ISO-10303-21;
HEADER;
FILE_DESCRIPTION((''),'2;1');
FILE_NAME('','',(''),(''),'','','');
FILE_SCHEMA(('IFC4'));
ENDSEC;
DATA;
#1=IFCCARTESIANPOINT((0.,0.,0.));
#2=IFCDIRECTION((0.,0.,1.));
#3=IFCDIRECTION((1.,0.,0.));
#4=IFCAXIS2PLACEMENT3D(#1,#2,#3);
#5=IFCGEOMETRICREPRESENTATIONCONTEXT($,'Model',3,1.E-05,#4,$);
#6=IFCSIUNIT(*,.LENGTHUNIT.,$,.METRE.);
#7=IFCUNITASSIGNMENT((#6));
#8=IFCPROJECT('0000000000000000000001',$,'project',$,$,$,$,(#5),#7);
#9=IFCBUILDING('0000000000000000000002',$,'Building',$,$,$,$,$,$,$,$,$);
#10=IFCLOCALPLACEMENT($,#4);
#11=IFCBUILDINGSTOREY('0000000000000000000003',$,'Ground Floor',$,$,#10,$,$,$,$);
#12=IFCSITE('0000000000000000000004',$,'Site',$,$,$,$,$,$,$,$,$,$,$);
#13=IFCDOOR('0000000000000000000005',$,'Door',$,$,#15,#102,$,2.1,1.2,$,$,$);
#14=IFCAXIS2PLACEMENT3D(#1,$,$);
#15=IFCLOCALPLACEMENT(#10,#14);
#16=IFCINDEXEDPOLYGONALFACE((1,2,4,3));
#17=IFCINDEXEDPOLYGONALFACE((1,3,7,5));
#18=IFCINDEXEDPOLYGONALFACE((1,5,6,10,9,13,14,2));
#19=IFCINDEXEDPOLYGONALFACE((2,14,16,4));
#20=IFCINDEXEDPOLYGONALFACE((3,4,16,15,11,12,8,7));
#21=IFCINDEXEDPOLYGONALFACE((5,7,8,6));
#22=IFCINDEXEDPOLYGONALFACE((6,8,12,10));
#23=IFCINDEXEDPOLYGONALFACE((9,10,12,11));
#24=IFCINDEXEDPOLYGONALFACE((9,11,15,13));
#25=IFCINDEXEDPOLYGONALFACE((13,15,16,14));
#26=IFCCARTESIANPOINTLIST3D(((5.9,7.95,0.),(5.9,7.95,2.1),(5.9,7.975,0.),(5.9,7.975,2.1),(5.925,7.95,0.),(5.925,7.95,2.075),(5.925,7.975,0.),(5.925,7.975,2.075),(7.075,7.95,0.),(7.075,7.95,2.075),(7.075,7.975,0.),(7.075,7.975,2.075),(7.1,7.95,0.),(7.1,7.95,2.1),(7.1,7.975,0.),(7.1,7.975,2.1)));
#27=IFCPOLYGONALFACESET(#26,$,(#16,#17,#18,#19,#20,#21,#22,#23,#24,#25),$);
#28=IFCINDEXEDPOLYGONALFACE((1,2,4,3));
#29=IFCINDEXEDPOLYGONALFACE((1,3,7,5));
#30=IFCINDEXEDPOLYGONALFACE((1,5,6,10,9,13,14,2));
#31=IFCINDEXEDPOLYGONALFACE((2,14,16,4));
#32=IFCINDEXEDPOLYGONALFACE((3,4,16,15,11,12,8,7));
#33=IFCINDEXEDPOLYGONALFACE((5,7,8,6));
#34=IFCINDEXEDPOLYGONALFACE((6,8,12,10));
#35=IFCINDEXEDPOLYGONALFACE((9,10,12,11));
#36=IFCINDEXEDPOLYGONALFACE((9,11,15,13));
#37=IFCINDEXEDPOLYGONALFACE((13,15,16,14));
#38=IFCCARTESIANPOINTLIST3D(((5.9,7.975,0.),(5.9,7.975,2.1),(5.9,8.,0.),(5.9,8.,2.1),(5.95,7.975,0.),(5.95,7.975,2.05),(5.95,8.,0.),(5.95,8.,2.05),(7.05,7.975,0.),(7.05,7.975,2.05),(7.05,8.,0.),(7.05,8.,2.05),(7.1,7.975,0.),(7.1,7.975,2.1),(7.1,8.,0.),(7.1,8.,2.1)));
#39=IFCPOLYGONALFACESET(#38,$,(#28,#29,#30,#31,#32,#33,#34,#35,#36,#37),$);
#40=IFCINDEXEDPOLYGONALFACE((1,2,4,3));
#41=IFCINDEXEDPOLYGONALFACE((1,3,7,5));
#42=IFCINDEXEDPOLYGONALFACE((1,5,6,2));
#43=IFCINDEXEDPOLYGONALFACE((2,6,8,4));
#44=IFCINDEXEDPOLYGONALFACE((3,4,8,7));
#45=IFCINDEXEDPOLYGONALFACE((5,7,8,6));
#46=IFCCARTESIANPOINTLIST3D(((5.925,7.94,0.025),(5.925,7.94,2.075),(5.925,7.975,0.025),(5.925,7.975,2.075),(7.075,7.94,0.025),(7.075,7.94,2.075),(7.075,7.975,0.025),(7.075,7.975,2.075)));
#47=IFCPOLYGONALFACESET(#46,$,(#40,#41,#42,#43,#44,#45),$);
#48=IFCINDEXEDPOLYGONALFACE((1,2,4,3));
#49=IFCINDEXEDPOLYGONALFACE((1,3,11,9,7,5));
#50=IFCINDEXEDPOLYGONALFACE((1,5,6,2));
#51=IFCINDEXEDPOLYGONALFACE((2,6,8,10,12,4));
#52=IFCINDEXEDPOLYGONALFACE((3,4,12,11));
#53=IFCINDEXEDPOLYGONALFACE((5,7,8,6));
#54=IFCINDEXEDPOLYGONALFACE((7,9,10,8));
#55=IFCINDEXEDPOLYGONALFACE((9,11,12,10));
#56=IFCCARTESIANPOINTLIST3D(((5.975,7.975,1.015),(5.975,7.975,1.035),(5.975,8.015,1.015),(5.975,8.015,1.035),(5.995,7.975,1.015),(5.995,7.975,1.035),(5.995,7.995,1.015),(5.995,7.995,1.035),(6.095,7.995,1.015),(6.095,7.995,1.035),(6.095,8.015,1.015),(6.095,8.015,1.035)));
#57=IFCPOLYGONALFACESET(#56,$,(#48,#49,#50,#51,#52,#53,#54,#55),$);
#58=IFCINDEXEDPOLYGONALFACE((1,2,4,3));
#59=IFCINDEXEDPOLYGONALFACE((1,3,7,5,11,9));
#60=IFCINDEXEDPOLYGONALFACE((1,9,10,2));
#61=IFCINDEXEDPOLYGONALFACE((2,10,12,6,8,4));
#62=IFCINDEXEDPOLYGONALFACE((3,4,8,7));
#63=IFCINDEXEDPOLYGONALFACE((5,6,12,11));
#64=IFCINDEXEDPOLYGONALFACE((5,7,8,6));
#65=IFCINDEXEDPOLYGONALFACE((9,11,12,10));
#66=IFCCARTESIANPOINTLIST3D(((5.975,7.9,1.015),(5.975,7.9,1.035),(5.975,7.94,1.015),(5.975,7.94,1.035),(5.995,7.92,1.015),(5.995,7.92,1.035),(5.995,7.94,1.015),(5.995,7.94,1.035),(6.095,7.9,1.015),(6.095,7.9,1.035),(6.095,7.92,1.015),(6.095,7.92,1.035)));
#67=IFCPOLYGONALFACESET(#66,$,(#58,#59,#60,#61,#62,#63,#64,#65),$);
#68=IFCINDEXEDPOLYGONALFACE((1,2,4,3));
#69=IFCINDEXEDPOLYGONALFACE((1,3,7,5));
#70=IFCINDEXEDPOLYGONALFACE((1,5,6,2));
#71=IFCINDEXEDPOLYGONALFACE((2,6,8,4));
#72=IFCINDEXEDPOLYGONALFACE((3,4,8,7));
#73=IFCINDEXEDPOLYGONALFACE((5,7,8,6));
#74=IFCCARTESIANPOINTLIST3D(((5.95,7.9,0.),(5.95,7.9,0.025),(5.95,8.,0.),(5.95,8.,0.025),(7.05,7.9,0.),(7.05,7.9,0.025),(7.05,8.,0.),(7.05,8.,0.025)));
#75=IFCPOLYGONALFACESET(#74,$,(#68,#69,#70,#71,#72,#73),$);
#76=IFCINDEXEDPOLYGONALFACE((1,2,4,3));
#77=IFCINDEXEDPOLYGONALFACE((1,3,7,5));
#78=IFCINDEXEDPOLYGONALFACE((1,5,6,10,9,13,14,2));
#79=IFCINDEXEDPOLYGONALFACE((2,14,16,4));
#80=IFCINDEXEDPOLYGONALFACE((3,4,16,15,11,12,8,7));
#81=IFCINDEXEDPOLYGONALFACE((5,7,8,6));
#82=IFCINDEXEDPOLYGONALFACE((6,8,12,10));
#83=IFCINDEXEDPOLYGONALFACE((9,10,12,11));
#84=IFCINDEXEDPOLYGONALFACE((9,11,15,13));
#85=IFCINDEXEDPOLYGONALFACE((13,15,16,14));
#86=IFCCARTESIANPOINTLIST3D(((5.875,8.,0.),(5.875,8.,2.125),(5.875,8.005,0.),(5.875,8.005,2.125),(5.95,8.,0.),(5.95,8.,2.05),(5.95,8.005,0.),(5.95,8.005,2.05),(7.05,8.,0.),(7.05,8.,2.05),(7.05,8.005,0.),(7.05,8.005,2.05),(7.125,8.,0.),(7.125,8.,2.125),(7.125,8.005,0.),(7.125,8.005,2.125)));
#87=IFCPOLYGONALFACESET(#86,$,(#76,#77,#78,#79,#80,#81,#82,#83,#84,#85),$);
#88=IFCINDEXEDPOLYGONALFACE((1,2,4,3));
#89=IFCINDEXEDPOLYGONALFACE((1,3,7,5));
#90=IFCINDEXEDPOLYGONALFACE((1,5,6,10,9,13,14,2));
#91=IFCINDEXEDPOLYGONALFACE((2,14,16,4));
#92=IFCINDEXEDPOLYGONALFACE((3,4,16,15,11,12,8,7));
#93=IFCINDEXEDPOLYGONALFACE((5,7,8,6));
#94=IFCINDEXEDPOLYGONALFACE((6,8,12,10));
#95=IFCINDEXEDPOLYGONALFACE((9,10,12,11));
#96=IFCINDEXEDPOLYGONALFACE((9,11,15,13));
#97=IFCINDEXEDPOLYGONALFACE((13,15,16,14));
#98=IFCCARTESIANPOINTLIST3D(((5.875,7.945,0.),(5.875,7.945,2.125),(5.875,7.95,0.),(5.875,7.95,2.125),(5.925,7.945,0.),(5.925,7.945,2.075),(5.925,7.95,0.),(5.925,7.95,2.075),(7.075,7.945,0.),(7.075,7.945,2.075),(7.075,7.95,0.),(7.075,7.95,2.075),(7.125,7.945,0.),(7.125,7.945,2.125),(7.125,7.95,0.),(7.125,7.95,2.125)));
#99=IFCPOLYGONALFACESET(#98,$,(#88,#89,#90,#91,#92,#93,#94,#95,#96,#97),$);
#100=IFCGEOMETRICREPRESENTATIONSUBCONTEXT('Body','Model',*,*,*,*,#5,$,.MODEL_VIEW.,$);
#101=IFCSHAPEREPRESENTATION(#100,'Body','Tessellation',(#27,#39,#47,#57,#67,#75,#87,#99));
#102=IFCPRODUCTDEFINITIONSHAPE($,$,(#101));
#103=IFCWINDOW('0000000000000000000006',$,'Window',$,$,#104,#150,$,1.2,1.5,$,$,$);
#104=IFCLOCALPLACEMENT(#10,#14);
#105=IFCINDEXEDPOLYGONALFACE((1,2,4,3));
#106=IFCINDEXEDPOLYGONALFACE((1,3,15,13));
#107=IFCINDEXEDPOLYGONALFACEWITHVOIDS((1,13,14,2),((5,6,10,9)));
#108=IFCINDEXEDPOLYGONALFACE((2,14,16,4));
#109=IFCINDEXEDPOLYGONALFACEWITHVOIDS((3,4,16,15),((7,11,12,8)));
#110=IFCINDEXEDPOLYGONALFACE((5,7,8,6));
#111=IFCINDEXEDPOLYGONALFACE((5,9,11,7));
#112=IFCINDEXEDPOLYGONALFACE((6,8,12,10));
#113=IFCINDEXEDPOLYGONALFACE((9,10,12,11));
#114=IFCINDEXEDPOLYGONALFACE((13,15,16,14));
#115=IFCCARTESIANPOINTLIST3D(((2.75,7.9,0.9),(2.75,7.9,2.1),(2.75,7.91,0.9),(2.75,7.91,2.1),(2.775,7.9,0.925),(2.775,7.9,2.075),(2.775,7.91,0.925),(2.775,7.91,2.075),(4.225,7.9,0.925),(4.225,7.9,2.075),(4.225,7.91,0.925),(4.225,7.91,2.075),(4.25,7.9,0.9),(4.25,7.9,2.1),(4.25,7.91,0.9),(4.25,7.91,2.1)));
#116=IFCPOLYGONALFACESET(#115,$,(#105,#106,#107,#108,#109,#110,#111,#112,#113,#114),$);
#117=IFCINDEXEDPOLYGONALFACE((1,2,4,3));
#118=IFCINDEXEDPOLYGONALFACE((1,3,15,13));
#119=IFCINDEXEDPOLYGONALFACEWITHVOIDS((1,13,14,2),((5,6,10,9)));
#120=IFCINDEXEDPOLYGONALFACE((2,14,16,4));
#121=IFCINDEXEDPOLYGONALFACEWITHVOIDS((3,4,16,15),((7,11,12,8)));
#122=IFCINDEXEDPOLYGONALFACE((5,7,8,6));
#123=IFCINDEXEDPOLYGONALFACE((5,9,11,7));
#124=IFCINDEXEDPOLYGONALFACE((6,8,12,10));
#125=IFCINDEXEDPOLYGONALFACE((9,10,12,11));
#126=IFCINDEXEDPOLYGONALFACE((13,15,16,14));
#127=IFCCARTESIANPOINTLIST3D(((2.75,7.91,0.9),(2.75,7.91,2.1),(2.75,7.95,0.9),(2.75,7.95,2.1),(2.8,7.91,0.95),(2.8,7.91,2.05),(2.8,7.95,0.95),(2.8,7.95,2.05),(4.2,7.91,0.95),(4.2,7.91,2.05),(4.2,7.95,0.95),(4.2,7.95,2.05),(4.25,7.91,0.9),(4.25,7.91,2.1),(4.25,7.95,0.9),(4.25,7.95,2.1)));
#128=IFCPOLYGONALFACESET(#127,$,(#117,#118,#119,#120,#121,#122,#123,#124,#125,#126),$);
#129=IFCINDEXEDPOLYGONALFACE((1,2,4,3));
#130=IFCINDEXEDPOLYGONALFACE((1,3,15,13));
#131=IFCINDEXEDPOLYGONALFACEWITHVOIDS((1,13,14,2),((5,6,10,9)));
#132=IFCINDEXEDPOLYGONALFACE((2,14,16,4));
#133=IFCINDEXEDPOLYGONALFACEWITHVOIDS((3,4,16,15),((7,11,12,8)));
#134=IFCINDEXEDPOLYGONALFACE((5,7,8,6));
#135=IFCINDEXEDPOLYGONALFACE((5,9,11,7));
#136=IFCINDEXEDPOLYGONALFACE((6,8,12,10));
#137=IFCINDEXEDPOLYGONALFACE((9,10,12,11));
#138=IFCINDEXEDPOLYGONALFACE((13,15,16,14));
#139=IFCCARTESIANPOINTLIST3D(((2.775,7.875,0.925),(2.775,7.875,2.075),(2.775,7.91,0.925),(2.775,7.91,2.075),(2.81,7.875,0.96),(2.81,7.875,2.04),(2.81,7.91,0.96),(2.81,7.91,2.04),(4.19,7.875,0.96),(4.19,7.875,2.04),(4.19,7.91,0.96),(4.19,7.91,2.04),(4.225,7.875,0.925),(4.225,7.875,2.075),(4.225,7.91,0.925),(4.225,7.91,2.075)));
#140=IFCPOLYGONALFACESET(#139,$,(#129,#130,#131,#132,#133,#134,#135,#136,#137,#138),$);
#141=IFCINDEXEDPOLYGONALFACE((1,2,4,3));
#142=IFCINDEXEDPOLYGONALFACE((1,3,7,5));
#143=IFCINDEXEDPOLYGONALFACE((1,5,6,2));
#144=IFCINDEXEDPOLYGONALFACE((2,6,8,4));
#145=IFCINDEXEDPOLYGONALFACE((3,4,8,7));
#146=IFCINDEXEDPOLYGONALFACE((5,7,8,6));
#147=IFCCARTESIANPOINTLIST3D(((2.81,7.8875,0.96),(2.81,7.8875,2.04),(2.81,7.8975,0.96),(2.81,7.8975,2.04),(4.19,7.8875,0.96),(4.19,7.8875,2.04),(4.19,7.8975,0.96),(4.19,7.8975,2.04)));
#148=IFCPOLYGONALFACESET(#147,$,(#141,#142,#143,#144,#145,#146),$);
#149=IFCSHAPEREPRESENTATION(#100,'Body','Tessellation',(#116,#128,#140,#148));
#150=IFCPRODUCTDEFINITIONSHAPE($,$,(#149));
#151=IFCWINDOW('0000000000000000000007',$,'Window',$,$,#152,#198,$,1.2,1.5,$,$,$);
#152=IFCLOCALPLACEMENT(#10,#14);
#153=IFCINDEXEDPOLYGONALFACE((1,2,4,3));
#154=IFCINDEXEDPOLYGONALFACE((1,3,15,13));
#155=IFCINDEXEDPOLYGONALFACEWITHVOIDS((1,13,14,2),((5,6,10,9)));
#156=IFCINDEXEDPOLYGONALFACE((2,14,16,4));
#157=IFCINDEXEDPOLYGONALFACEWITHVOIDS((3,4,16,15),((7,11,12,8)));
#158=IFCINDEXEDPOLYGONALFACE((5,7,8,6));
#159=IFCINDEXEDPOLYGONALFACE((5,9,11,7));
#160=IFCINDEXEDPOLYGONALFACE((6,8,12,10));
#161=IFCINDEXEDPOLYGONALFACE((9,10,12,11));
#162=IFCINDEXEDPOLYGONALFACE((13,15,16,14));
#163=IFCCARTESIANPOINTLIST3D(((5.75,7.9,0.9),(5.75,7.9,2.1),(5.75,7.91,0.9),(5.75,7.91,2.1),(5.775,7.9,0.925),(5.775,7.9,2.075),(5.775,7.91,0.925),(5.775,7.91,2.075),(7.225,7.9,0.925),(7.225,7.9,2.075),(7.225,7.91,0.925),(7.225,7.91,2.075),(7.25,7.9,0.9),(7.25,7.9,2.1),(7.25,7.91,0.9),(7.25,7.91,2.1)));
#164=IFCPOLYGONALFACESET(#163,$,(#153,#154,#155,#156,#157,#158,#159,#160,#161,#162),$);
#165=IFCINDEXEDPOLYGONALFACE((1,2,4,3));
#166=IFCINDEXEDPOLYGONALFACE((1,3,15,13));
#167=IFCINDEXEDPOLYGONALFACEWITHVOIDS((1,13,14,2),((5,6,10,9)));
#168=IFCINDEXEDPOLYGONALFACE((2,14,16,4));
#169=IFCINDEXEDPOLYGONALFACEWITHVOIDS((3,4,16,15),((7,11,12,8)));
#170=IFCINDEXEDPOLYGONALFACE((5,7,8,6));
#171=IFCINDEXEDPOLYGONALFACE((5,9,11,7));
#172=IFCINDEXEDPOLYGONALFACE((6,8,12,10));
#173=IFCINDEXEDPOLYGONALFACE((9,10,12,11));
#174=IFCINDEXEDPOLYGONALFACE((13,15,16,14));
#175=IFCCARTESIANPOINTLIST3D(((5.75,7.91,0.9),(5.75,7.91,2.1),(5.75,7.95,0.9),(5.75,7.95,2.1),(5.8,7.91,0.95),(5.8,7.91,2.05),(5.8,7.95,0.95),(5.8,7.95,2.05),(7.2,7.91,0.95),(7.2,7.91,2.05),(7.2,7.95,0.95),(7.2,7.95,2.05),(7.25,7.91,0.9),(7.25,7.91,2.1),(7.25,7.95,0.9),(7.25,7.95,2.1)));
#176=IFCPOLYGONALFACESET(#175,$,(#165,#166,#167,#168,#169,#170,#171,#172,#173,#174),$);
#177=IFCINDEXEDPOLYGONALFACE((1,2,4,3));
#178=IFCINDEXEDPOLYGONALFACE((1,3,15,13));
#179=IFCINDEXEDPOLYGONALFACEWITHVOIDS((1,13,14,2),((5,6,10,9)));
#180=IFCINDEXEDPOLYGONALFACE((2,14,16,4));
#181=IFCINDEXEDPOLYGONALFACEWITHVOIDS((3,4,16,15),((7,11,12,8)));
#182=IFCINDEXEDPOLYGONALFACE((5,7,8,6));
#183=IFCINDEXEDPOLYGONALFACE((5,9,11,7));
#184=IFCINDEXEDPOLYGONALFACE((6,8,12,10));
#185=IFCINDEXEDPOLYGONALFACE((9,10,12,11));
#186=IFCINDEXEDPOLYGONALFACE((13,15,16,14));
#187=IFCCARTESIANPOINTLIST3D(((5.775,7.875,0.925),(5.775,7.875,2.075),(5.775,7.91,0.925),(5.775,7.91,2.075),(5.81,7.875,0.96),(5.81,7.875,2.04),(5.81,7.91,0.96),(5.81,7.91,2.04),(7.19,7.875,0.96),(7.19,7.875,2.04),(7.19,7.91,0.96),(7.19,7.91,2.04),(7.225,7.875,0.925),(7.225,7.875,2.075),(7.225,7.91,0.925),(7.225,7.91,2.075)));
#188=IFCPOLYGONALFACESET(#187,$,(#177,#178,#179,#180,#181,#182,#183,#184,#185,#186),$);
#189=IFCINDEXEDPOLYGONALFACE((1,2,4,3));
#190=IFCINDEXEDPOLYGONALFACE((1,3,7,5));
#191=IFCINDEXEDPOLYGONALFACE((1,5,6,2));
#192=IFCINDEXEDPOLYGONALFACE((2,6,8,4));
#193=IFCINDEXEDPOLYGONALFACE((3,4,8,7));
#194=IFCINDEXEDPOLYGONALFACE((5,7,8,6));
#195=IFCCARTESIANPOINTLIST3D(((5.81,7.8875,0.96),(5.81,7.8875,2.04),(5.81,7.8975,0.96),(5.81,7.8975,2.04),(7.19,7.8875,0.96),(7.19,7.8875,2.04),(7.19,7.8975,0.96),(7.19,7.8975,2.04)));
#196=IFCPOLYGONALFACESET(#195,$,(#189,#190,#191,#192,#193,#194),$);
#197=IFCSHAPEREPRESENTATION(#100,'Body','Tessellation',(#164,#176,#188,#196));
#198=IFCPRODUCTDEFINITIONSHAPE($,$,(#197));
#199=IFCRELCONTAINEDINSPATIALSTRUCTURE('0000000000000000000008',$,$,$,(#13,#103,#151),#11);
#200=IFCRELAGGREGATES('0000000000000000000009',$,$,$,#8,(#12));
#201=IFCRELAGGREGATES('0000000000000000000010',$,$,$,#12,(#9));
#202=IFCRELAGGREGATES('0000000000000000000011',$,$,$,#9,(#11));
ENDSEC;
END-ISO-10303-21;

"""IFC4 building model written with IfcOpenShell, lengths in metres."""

from ifc_helpers import new_model, si_unit, frame, origin_with_axes, place, context, subcontext, project, spatial, line, indexed_curve, outline, extrude, element, save


model = new_model("IFC4")

# Units and contexts
model_context = context("Model", 3, precision=1e-05, world=origin_with_axes())
body_context = subcontext(model_context, "Body", "Model", "MODEL_VIEW")
ifc_project = project(units=[si_unit("LENGTHUNIT", "METRE")], contexts=[model_context])

# Site, building, storey
site = spatial("IfcSite", under=ifc_project, Name="Site")
building = spatial("IfcBuilding", under=site, Name="Building")
storey_placement = place(None, origin_with_axes())
storey = spatial("IfcBuildingStorey", under=building, at=storey_placement, Name="Ground Floor")

# Door
door_1_placement = place(storey_placement, frame((7.1, 8.0, 0.0), z_axis=(0.0, 0.0, 1.0), x_axis=(-1.0, 0.0, 0.0)))
element("IfcDoor", 1, at=door_1_placement, inside=storey, Name="Door", OverallHeight=2.1, OverallWidth=1.2, context=body_context, shape_type="SweptSolid", body=[
    extrude(outline(indexed_curve([(0.0, 0.0), (0.0, 2.1), (1.2, 2.1), (1.2, 0.0), (1.175, 0.0), (1.175, 2.075), (0.025, 2.075), (0.025, 0.0)], segments=[line(1, 2, 3, 4, 5, 6, 7, 8, 1)])), frame((0.0, 0.025, 0.0), z_axis=(0.0, -1.0, 0.0), x_axis=(1.0, 0.0, 0.0)), (0.0, 0.0, -1.0), 0.025),
    extrude(outline(indexed_curve([(0.0, 0.0), (0.0, 2.1), (1.2, 2.1), (1.2, 0.0), (1.15, 0.0), (1.15, 2.05), (0.05, 2.05), (0.05, 0.0)], segments=[line(1, 2, 3, 4, 5, 6, 7, 8, 1)])), frame((0.0, 0.0, 0.0), z_axis=(0.0, -1.0, 0.0), x_axis=(1.0, 0.0, 0.0)), (0.0, 0.0, -1.0), 0.025),
    extrude(outline(indexed_curve([(0.0, 0.0), (1.15, 0.0), (1.15, 0.035), (0.0, 0.035)], segments=[line(1, 2, 3, 4, 1)])), frame((0.025, 0.025, 0.025), z_axis=(0.0, 0.0, 1.0), x_axis=(1.0, 0.0, 0.0)), (0.0, 0.0, 1.0), 2.05),
    extrude(outline(indexed_curve([(0.0, 0.0), (0.0, -0.04), (-0.12, -0.04), (-0.12, -0.02), (-0.02, -0.02), (-0.02, 0.0)], segments=[line(1, 2, 3, 4, 5, 6, 1)])), frame((1.125, 0.025, 1.015), z_axis=(0.0, 0.0, 1.0), x_axis=(1.0, 0.0, 0.0)), (0.0, 0.0, 1.0), 0.02),
    extrude(outline(indexed_curve([(0.0, 0.0), (0.0, 0.04), (-0.12, 0.04), (-0.12, 0.02), (-0.02, 0.02), (-0.02, 0.0)], segments=[line(1, 2, 3, 4, 5, 6, 1)])), frame((1.125, 0.06, 1.015), z_axis=(0.0, 0.0, 1.0), x_axis=(1.0, 0.0, 0.0)), (0.0, 0.0, 1.0), 0.02),
    extrude(outline(indexed_curve([(0.0, 0.0), (1.1, 0.0), (1.1, 0.1), (0.0, 0.1)], segments=[line(1, 2, 3, 4, 1)])), frame((0.05, 0.0, 0.0), z_axis=(0.0, 0.0, 1.0), x_axis=(1.0, 0.0, 0.0)), (0.0, 0.0, 1.0), 0.025),
    extrude(outline(indexed_curve([(0.0, 0.0), (0.0, 2.125), (1.25, 2.125), (1.25, 0.0), (1.175, 0.0), (1.175, 2.05), (0.075, 2.05), (0.075, 0.0)], segments=[line(1, 2, 3, 4, 5, 6, 7, 8, 1)])), frame((-0.025, -0.005, 0.0), z_axis=(0.0, -1.0, 0.0), x_axis=(1.0, 0.0, 0.0)), (0.0, 0.0, -1.0), 0.005),
    extrude(outline(indexed_curve([(0.0, 0.0), (0.0, 2.125), (1.25, 2.125), (1.25, 0.0), (1.2, 0.0), (1.2, 2.075), (0.05, 2.075), (0.05, 0.0)], segments=[line(1, 2, 3, 4, 5, 6, 7, 8, 1)])), frame((-0.025, 0.05, 0.0), z_axis=(0.0, -1.0, 0.0), x_axis=(1.0, 0.0, 0.0)), (0.0, 0.0, -1.0), 0.005),
])

# Windows
for number, where, z_axis, x_axis, name in (
    (2, (4.25, 8.0, 0.9), (0.0, 0.0, 1.0), (-1.0, 0.0, 0.0), "Window"),
    (3, (7.25, 8.0, 0.9), (0.0, 0.0, 1.0), (-1.0, 0.0, 0.0), "Window"),
):
    element("IfcWindow", number, at=place(storey_placement, frame(where, z_axis=z_axis, x_axis=x_axis)), inside=storey, Name=name, OverallHeight=1.2, OverallWidth=1.5, context=body_context, shape_type="SweptSolid", body=[
        extrude(outline(indexed_curve([(0.0, 0.0), (1.5, 0.0), (1.5, 1.2), (0.0, 1.2)], segments=[line(1, 2, 3, 4, 1)]), holes=[indexed_curve([(0.025, 0.025), (1.475, 0.025), (1.475, 1.175), (0.025, 1.175)], segments=[line(1, 2, 3, 4, 1)])]), frame((0.0, 0.09, 0.0), z_axis=(0.0, -1.0, 0.0), x_axis=(1.0, 0.0, 0.0)), (0.0, 0.0, -1.0), 0.01),
        extrude(outline(indexed_curve([(0.0, 0.0), (1.5, 0.0), (1.5, 1.2), (0.0, 1.2)], segments=[line(1, 2, 3, 4, 1)]), holes=[indexed_curve([(0.05, 0.05), (1.45, 0.05), (1.45, 1.15), (0.05, 1.15)], segments=[line(1, 2, 3, 4, 1)])]), frame((0.0, 0.05, 0.0), z_axis=(0.0, -1.0, 0.0), x_axis=(1.0, 0.0, 0.0)), (0.0, 0.0, -1.0), 0.04),
        extrude(outline(indexed_curve([(0.0, 0.0), (1.45, 0.0), (1.45, 1.15), (0.0, 1.15)], segments=[line(1, 2, 3, 4, 1)]), holes=[indexed_curve([(0.035, 0.035), (1.415, 0.035), (1.415, 1.115), (0.035, 1.115)], segments=[line(1, 2, 3, 4, 1)])]), frame((0.025, 0.09, 0.025), z_axis=(0.0, -1.0, 0.0), x_axis=(1.0, 0.0, 0.0)), (0.0, 0.0, -1.0), 0.035),
        extrude(outline(indexed_curve([(0.035, 0.035), (1.415, 0.035), (1.415, 1.115), (0.035, 1.115)], segments=[line(1, 2, 3, 4, 1)])), frame((0.025, 0.1025, 0.025), z_axis=(0.0, -1.0, 0.0), x_axis=(1.0, 0.0, 0.0)), (0.0, 0.0, -1.0), 0.01),
    ])

save(model, "model.ifc")
